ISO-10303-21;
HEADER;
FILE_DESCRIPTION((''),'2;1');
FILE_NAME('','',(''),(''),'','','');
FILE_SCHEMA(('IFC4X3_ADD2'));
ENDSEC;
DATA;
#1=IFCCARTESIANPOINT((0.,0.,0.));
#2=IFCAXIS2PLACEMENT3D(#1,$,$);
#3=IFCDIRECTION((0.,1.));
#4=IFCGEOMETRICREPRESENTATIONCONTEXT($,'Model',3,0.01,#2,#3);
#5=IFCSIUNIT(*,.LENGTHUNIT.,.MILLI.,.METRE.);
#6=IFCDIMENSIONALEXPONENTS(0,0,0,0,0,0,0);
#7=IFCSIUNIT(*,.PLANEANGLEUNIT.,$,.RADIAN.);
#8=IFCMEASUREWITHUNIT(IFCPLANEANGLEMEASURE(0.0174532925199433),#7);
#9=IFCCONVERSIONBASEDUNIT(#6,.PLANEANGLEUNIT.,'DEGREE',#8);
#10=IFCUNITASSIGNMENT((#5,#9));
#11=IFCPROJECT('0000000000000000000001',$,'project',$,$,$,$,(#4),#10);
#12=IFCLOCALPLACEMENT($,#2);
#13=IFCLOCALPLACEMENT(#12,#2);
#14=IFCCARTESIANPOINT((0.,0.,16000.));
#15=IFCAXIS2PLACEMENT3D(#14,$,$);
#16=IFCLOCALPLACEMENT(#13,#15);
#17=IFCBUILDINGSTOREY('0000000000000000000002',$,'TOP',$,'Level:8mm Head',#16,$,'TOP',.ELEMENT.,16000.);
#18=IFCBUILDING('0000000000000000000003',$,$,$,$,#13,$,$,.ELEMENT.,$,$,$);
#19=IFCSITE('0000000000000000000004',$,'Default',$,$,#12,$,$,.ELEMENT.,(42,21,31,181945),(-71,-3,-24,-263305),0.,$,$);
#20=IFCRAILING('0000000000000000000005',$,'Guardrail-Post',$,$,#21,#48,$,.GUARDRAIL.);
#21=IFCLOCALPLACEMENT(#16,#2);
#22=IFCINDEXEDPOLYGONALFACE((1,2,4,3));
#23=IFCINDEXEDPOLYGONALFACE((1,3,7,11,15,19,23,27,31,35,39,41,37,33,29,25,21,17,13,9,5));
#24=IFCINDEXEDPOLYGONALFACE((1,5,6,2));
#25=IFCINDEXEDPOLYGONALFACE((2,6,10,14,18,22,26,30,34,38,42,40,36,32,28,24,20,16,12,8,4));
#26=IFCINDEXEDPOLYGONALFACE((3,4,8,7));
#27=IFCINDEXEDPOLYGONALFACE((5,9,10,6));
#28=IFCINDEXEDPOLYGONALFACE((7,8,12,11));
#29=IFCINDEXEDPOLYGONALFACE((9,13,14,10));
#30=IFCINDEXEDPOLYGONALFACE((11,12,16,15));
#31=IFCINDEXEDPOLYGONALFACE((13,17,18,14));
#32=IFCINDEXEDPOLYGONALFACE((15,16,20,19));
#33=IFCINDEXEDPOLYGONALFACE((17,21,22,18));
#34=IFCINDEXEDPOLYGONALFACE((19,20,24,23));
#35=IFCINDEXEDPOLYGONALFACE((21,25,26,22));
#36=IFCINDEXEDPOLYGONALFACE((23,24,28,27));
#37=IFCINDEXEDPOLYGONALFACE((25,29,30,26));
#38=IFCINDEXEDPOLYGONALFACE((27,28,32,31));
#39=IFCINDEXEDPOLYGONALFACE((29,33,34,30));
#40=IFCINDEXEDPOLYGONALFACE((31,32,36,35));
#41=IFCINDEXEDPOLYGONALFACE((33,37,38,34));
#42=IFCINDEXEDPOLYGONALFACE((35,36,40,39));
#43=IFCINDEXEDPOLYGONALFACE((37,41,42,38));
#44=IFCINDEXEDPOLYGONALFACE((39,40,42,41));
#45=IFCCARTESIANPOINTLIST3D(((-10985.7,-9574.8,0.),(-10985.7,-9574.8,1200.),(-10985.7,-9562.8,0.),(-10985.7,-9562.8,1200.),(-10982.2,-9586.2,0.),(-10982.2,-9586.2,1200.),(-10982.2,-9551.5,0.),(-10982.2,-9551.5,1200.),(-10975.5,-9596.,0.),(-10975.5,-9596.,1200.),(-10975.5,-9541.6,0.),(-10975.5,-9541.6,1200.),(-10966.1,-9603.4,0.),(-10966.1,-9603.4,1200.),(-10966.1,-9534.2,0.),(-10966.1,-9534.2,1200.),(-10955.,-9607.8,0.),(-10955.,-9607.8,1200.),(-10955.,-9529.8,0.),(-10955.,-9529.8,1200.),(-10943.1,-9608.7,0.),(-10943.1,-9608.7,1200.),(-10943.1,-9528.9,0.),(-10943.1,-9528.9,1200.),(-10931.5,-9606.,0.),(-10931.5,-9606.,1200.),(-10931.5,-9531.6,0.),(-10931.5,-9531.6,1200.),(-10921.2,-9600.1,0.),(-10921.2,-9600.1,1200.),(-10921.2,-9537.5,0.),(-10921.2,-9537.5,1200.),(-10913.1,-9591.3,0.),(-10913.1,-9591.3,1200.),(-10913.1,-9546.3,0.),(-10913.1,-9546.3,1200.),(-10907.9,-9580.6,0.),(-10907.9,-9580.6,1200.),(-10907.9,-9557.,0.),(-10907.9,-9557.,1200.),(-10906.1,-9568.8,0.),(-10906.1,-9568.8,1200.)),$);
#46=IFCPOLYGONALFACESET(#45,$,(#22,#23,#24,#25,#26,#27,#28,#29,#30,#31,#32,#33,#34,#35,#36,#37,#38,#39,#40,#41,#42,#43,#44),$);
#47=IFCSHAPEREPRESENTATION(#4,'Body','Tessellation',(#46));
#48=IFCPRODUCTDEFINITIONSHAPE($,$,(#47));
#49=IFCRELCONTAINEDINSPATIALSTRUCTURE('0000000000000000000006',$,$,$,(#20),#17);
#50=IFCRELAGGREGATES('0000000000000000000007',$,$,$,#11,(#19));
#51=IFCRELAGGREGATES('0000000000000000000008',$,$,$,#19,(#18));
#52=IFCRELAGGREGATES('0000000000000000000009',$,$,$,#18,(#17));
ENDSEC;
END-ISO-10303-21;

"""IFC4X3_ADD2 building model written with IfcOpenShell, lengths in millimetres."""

from ifc_helpers import new_model, entity, si_unit, converted_unit, direction, frame, origin, origin_with_axes, origin_2d, place, context, project, spatial, circle, extrude, element, save


model = new_model("IFC4X3_ADD2")

# Units and contexts
model_context = context("Model", 3, precision=0.01, world=origin(), true_north=direction((0.0, 1.0)))
ifc_project = project(units=[si_unit("LENGTHUNIT", "METRE", prefix="MILLI"), converted_unit("PLANEANGLEUNIT", "DEGREE", entity("IfcPlaneAngleMeasure", 0.0174532925199433), si_unit("PLANEANGLEUNIT", "RADIAN"), dimensions=[0, 0, 0, 0, 0, 0, 0])], contexts=[model_context])

# Site, building, storey
site_placement = place(None, origin())
site = spatial("IfcSite", under=ifc_project, at=site_placement, Name="Default", CompositionType="ELEMENT", RefLatitude=(42, 21, 31, 181945), RefLongitude=(-71, -3, -24, -263305), RefElevation=0.0)
building_placement = place(site_placement, origin())
building = spatial("IfcBuilding", under=site, at=building_placement, CompositionType="ELEMENT")
storey_placement = place(building_placement, frame((0.0, 0.0, 16000.0)))
storey = spatial("IfcBuildingStorey", under=building, at=storey_placement, Name="TOP", ObjectType="Level:8mm Head", LongName="TOP", CompositionType="ELEMENT", Elevation=16000.0)

# Railing
for number, where, z_axis, x_axis, name in (
    (1, (-10946.1, -9568.8, 16000.0), (0.0, 0.0, 1.0), (1.0, 0.0, 0.0), "Guardrail-Post"),
):
    element("IfcRailing", number, at=place(None, frame(where, z_axis=z_axis, x_axis=x_axis)), inside=storey, Name=name, PredefinedType="GUARDRAIL", context=model_context, shape_type="SweptSolid", body=[
        extrude(circle(Radius=40.0, at=origin_2d()), origin_with_axes(), (0.0, 0.0, 1.0), 1200.0),
    ])

save(model, "model.ifc")
